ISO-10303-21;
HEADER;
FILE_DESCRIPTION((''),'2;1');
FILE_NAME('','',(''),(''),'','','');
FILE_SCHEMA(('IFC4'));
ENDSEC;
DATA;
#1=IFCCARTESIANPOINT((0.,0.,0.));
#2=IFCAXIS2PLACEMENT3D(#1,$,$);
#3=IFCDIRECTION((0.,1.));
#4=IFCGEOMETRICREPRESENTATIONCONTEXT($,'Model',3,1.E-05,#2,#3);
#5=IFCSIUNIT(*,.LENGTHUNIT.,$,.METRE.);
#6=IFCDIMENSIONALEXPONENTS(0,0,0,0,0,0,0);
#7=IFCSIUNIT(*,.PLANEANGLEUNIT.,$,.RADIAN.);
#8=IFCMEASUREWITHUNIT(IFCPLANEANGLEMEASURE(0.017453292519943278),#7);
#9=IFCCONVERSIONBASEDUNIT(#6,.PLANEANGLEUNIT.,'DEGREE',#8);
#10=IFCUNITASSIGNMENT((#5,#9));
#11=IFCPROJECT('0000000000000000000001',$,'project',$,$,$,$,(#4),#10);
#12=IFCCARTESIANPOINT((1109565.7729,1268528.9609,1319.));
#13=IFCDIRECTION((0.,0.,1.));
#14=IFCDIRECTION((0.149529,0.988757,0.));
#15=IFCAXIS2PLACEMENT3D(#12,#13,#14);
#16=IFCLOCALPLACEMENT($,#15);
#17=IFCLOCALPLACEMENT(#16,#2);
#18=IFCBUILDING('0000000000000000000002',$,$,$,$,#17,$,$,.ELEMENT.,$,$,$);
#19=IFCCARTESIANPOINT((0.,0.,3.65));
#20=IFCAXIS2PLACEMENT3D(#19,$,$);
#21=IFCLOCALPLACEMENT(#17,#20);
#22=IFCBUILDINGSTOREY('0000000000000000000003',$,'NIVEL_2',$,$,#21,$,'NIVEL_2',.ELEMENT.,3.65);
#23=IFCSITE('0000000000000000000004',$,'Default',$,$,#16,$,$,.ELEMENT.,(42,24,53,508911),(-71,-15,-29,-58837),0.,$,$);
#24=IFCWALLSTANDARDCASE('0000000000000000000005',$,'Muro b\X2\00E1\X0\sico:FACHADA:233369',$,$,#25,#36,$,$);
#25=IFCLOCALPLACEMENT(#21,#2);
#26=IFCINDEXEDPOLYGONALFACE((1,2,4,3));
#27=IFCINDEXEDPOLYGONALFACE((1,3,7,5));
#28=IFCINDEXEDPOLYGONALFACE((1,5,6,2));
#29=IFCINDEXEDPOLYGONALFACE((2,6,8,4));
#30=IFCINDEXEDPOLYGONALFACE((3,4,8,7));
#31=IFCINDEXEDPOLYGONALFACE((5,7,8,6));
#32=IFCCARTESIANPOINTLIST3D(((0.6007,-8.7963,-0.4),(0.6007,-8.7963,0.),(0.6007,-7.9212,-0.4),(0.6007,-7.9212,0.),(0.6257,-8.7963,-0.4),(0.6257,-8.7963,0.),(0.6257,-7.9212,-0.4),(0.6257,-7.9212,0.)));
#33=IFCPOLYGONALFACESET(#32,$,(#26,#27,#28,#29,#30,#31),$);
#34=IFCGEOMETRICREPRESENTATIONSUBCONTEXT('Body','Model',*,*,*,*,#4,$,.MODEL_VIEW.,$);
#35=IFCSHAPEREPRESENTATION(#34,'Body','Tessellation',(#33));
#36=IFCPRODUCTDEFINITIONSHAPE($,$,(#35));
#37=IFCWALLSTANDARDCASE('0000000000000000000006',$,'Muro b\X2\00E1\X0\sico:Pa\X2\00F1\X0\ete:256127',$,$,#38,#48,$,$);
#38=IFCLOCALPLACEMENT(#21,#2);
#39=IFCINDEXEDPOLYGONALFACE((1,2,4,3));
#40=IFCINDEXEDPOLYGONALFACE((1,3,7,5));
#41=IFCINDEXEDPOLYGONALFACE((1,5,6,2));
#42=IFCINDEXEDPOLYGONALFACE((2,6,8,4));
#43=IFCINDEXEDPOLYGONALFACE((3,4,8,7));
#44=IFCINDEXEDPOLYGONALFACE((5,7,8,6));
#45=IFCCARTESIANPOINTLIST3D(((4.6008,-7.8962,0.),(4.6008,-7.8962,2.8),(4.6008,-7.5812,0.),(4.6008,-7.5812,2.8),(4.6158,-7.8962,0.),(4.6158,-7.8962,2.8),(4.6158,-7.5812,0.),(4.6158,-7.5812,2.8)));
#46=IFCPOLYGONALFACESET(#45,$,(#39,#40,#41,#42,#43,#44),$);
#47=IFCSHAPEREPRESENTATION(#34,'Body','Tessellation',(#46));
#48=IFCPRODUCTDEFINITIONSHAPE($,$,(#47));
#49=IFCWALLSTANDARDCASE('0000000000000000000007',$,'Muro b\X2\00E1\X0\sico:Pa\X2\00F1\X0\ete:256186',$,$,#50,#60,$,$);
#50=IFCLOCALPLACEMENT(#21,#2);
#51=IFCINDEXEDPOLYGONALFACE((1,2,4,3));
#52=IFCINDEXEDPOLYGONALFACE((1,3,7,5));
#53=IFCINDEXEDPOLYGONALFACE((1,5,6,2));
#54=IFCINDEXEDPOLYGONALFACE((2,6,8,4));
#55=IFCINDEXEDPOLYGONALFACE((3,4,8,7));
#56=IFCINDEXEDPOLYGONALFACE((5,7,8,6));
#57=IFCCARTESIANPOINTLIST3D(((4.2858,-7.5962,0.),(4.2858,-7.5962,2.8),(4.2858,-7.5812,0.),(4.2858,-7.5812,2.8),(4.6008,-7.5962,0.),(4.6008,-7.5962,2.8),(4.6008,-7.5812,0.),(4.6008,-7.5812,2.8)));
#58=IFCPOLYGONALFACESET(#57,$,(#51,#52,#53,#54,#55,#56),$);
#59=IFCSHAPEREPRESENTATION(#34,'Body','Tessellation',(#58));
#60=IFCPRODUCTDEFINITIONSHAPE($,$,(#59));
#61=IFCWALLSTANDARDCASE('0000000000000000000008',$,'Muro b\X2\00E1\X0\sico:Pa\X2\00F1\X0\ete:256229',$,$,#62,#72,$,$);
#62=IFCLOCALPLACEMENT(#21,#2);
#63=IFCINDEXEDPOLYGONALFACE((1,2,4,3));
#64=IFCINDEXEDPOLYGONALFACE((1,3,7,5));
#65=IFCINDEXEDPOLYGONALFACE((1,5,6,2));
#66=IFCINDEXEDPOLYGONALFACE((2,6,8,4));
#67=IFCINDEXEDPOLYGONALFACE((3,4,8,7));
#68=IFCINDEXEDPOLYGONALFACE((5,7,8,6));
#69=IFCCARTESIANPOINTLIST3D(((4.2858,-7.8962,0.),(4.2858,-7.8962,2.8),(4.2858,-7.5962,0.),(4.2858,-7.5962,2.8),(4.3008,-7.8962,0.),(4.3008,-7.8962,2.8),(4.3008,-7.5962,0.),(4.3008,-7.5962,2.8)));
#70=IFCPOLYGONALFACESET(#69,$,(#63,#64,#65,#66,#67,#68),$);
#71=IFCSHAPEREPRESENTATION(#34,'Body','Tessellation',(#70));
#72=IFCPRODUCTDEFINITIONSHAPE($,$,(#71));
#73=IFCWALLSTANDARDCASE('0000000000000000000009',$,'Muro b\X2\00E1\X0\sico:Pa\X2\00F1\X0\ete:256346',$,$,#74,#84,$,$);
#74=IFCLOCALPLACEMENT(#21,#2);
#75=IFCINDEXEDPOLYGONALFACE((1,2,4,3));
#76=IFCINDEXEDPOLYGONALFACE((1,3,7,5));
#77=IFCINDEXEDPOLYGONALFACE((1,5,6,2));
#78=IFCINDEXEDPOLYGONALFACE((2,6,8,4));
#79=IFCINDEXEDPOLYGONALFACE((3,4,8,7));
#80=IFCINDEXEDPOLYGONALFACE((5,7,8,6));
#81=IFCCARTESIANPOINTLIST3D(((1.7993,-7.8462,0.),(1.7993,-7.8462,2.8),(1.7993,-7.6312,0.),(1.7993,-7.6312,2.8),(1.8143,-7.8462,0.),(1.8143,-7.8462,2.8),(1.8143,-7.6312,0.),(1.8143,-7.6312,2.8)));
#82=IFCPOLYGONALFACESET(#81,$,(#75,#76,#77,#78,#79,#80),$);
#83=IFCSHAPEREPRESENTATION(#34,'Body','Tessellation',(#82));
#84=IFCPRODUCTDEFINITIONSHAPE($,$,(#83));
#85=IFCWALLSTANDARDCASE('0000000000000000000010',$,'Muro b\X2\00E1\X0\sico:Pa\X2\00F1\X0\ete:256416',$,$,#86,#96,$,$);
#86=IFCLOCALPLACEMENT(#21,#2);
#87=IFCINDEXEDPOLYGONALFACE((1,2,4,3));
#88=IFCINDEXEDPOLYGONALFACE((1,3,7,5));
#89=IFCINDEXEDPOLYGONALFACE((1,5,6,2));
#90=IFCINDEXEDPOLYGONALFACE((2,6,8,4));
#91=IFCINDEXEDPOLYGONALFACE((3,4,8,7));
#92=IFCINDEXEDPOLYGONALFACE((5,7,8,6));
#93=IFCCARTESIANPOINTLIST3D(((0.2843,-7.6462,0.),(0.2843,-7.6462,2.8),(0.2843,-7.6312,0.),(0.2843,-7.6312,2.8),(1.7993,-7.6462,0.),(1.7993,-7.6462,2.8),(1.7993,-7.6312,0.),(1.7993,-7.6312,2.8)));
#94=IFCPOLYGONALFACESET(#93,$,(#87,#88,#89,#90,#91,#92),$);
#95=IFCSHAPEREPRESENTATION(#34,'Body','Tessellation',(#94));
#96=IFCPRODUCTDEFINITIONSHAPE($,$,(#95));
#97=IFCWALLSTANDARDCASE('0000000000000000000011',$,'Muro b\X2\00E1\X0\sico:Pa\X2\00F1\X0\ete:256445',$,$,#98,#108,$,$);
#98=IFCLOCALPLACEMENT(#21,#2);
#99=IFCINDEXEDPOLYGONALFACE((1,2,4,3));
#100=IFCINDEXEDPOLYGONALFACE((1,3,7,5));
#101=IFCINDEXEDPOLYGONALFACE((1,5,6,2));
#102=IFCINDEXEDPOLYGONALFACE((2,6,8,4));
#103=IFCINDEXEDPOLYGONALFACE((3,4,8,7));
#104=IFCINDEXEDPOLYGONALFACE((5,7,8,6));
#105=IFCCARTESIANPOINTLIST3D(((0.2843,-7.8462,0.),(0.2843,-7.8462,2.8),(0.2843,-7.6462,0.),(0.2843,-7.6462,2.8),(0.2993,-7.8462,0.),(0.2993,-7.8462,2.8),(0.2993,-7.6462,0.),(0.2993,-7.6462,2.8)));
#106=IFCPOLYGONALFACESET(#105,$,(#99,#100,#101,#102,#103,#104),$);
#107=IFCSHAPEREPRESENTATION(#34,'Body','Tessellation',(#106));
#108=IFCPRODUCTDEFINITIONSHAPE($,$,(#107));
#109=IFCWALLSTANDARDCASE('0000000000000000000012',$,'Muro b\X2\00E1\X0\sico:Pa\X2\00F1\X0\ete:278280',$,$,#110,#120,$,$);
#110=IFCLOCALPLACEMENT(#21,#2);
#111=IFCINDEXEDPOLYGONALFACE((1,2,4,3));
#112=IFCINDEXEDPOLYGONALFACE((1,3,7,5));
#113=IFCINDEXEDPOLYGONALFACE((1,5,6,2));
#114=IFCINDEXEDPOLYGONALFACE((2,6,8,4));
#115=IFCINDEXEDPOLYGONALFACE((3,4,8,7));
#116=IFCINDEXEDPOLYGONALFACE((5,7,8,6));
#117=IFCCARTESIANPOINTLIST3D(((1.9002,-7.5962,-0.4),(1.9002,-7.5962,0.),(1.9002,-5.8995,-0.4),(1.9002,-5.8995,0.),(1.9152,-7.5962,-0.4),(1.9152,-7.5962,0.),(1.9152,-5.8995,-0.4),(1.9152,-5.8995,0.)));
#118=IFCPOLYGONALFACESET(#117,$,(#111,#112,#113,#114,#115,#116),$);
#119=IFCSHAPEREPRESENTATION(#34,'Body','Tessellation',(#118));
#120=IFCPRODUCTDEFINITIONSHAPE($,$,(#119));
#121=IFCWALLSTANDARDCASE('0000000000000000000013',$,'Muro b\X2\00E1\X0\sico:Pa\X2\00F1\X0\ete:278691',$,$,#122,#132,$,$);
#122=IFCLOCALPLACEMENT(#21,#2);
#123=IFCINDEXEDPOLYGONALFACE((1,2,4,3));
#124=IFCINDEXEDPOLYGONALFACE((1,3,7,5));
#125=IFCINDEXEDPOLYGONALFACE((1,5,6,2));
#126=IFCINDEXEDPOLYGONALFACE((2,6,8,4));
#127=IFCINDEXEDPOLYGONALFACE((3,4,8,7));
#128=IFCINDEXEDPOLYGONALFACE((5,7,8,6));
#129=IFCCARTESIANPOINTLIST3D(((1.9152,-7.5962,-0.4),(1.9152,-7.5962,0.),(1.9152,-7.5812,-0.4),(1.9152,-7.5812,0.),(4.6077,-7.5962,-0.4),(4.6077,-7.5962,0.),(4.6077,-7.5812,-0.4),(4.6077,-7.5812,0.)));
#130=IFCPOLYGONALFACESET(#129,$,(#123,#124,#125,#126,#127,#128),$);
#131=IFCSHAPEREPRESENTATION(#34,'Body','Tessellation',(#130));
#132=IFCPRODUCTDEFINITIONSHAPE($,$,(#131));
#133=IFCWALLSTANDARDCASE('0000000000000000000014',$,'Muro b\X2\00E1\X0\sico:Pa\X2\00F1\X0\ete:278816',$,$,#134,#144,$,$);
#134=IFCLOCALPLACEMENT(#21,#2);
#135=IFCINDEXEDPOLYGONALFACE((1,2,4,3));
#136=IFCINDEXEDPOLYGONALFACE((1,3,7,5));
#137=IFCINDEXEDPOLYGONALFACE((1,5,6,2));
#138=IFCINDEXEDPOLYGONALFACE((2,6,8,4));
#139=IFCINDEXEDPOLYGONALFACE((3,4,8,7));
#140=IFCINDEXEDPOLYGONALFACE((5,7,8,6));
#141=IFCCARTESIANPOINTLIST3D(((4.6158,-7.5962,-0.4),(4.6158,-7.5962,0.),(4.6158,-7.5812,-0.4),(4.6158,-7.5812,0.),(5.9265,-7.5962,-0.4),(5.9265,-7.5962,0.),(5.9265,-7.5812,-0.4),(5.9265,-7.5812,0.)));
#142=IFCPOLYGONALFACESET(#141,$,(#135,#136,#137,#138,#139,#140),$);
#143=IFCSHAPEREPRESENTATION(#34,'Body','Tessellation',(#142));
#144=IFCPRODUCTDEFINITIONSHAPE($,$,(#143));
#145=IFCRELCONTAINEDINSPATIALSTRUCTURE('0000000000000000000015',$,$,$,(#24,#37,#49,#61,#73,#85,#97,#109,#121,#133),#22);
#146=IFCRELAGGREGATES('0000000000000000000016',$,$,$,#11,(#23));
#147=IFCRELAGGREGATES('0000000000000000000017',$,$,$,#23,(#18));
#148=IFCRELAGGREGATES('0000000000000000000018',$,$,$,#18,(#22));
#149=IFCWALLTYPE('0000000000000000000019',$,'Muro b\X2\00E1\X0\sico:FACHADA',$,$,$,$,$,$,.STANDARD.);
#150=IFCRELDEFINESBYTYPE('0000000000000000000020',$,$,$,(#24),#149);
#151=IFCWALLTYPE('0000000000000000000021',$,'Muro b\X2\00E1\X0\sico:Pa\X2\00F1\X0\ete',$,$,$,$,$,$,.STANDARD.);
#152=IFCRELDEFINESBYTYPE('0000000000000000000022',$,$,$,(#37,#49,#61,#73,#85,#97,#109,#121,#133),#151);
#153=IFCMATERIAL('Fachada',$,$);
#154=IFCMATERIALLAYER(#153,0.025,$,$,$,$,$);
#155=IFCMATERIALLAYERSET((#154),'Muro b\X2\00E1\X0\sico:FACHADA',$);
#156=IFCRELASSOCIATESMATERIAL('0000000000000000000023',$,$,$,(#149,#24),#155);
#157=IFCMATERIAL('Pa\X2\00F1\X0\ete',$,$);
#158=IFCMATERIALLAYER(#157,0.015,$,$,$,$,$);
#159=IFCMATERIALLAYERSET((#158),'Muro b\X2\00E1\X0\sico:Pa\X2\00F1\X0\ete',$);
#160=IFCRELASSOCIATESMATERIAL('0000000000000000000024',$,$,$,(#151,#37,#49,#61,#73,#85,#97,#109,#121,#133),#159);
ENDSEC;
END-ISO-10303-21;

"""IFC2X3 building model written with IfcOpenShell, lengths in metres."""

from ifc_helpers import new_model, entity, si_unit, converted_unit, direction, frame, frame_2d, origin, place, context, subcontext, project, spatial, rectangle, extrude, material, layer, layer_set, layer_usage, type_object, element, save


model = new_model("IFC2X3")

# Units and contexts
model_context = context("Model", 3, precision=1e-05, world=origin(), true_north=direction((0.0, 1.0)))
body_context = subcontext(model_context, "Body", "Model", "MODEL_VIEW")
ifc_project = project(units=[si_unit("LENGTHUNIT", "METRE"), converted_unit("PLANEANGLEUNIT", "DEGREE", entity("IfcPlaneAngleMeasure", 0.017453292519943278), si_unit("PLANEANGLEUNIT", "RADIAN"), dimensions=[0, 0, 0, 0, 0, 0, 0])], contexts=[model_context])

# Site, building, storey
site_placement = place(None, frame((1109565.7729, 1268528.9609, 1319.0), z_axis=(0.0, 0.0, 1.0), x_axis=(0.149529, 0.988757, 0.0)))
site = spatial("IfcSite", under=ifc_project, at=site_placement, Name="Default", CompositionType="ELEMENT", RefLatitude=(42, 24, 53, 508911), RefLongitude=(-71, -15, -29, -58837), RefElevation=0.0)
building_placement = place(site_placement, origin())
building = spatial("IfcBuilding", under=site, at=building_placement, CompositionType="ELEMENT")
storey_placement = place(building_placement, frame((0.0, 0.0, 3.65)))
storey = spatial("IfcBuildingStorey", under=building, at=storey_placement, Name="NIVEL_2", LongName="NIVEL_2", CompositionType="ELEMENT", Elevation=3.65)

# Shared definitions
ifc_material_1 = material(Name="Pañete")

# Walls
ifc_material_2 = material(Name="Fachada")
ifc_layer_1 = layer(ifc_material_2, 0.025)
ifc_layer_set_1 = layer_set([ifc_layer_1], Name="Muro básico:FACHADA")
wall_type_1 = type_object("IfcWallType", Name="Muro básico:FACHADA", PredefinedType="STANDARD", material=ifc_layer_set_1)
ifc_layer_usage_1 = layer_usage(ifc_layer_set_1, "AXIS2", "NEGATIVE", 0.0125)
wall_1_placement = place(storey_placement, frame((0.6132, -8.7963, -0.4), z_axis=(0.0, 0.0, 1.0), x_axis=(0.0, 1.0, 0.0)))
element("IfcWallStandardCase", 1, at=wall_1_placement, inside=storey, type_object=wall_type_1, material=ifc_layer_usage_1, Name="Muro básico:FACHADA:233369", context=body_context, shape_type="SweptSolid", body=[
    extrude(rectangle(XDim=0.8751, YDim=0.025, at=frame_2d((0.4376, 0.0), x_axis=(-1.0, 0.0))), origin(), (0.0, 0.0, 1.0), 0.4),
])
ifc_layer_2 = layer(ifc_material_1, 0.015)
ifc_layer_set_2 = layer_set([ifc_layer_2], Name="Muro básico:Pañete")
ifc_layer_usage_2 = layer_usage(ifc_layer_set_2, "AXIS2", "POSITIVE", -0.0075)
wall_type_2 = type_object("IfcWallType", Name="Muro básico:Pañete", PredefinedType="STANDARD", material=ifc_layer_set_2)
wall_2_placement = place(storey_placement, frame((4.6083, -7.8962, 0.0), z_axis=(0.0, 0.0, 1.0), x_axis=(0.0, 1.0, 0.0)))
element("IfcWallStandardCase", 2, at=wall_2_placement, inside=storey, type_object=wall_type_2, material=ifc_layer_usage_2, Name="Muro básico:Pañete:256127", context=body_context, shape_type="SweptSolid", body=[
    extrude(rectangle(XDim=0.315, YDim=0.015, at=frame_2d((0.1575, 0.0), x_axis=(-1.0, 0.0))), origin(), (0.0, 0.0, 1.0), 2.8),
])
ifc_layer_usage_3 = layer_usage(ifc_layer_set_2, "AXIS2", "POSITIVE", -0.0075)
wall_3_placement = place(storey_placement, frame((4.6008, -7.5887, 0.0), z_axis=(0.0, 0.0, 1.0), x_axis=(-1.0, 0.0, 0.0)))
element("IfcWallStandardCase", 3, at=wall_3_placement, inside=storey, type_object=wall_type_2, material=ifc_layer_usage_3, Name="Muro básico:Pañete:256186", context=body_context, shape_type="SweptSolid", body=[
    extrude(rectangle(XDim=0.315, YDim=0.015, at=frame_2d((0.1575, 0.0), x_axis=(-1.0, 0.0))), origin(), (0.0, 0.0, 1.0), 2.8),
])
ifc_layer_usage_4 = layer_usage(ifc_layer_set_2, "AXIS2", "POSITIVE", -0.0075)
wall_4_placement = place(storey_placement, frame((4.2933, -7.5962, 0.0), z_axis=(0.0, 0.0, 1.0), x_axis=(0.0, -1.0, 0.0)))
element("IfcWallStandardCase", 4, at=wall_4_placement, inside=storey, type_object=wall_type_2, material=ifc_layer_usage_4, Name="Muro básico:Pañete:256229", context=body_context, shape_type="SweptSolid", body=[
    extrude(rectangle(XDim=0.3, YDim=0.015, at=frame_2d((0.15, 0.0), x_axis=(-1.0, 0.0))), origin(), (0.0, 0.0, 1.0), 2.8),
])
ifc_layer_usage_5 = layer_usage(ifc_layer_set_2, "AXIS2", "POSITIVE", -0.0075)
wall_5_placement = place(storey_placement, frame((1.8068, -7.8462, 0.0), z_axis=(0.0, 0.0, 1.0), x_axis=(0.0, 1.0, 0.0)))
element("IfcWallStandardCase", 5, at=wall_5_placement, inside=storey, type_object=wall_type_2, material=ifc_layer_usage_5, Name="Muro básico:Pañete:256346", context=body_context, shape_type="SweptSolid", body=[
    extrude(rectangle(XDim=0.215, YDim=0.015, at=frame_2d((0.1075, 0.0), x_axis=(-1.0, 0.0))), origin(), (0.0, 0.0, 1.0), 2.8),
])
ifc_layer_usage_6 = layer_usage(ifc_layer_set_2, "AXIS2", "POSITIVE", -0.0075)
wall_6_placement = place(storey_placement, frame((1.7993, -7.6387, 0.0), z_axis=(0.0, 0.0, 1.0), x_axis=(-1.0, 0.0, 0.0)))
element("IfcWallStandardCase", 6, at=wall_6_placement, inside=storey, type_object=wall_type_2, material=ifc_layer_usage_6, Name="Muro básico:Pañete:256416", context=body_context, shape_type="SweptSolid", body=[
    extrude(rectangle(XDim=1.515, YDim=0.015, at=frame_2d((0.7575, 0.0), x_axis=(-1.0, 0.0))), origin(), (0.0, 0.0, 1.0), 2.8),
])
ifc_layer_usage_7 = layer_usage(ifc_layer_set_2, "AXIS2", "POSITIVE", -0.0075)
wall_7_placement = place(storey_placement, frame((0.2918, -7.6462, 0.0), z_axis=(0.0, 0.0, 1.0), x_axis=(0.0, -1.0, 0.0)))
element("IfcWallStandardCase", 7, at=wall_7_placement, inside=storey, type_object=wall_type_2, material=ifc_layer_usage_7, Name="Muro básico:Pañete:256445", context=body_context, shape_type="SweptSolid", body=[
    extrude(rectangle(XDim=0.2, YDim=0.015, at=frame_2d((0.1, 0.0), x_axis=(-1.0, 0.0))), origin(), (0.0, 0.0, 1.0), 2.8),
])
ifc_layer_usage_8 = layer_usage(ifc_layer_set_2, "AXIS2", "NEGATIVE", 0.0075)
wall_8_placement = place(storey_placement, frame((1.9077, -5.8995, -0.4), z_axis=(0.0, 0.0, 1.0), x_axis=(0.0, -1.0, 0.0)))
element("IfcWallStandardCase", 8, at=wall_8_placement, inside=storey, type_object=wall_type_2, material=ifc_layer_usage_8, Name="Muro básico:Pañete:278280", context=body_context, shape_type="SweptSolid", body=[
    extrude(rectangle(XDim=1.6967, YDim=0.015, at=frame_2d((0.8483, 0.0), x_axis=(-1.0, 0.0))), origin(), (0.0, 0.0, 1.0), 0.4),
])
ifc_layer_usage_9 = layer_usage(ifc_layer_set_2, "AXIS2", "NEGATIVE", 0.0075)
wall_9_placement = place(storey_placement, frame((1.9152, -7.5887, -0.4)))
element("IfcWallStandardCase", 9, at=wall_9_placement, inside=storey, type_object=wall_type_2, material=ifc_layer_usage_9, Name="Muro básico:Pañete:278691", context=body_context, shape_type="SweptSolid", body=[
    extrude(rectangle(XDim=2.6925, YDim=0.015, at=frame_2d((1.3463, 0.0), x_axis=(-1.0, 0.0))), origin(), (0.0, 0.0, 1.0), 0.4),
])
ifc_layer_usage_10 = layer_usage(ifc_layer_set_2, "AXIS2", "NEGATIVE", 0.0075)
wall_10_placement = place(storey_placement, frame((4.6158, -7.5887, -0.4)))
element("IfcWallStandardCase", 10, at=wall_10_placement, inside=storey, type_object=wall_type_2, material=ifc_layer_usage_10, Name="Muro básico:Pañete:278816", context=body_context, shape_type="SweptSolid", body=[
    extrude(rectangle(XDim=1.3107, YDim=0.015, at=frame_2d((0.6554, 0.0), x_axis=(-1.0, 0.0))), origin(), (0.0, 0.0, 1.0), 0.4),
])

save(model, "model.ifc")
